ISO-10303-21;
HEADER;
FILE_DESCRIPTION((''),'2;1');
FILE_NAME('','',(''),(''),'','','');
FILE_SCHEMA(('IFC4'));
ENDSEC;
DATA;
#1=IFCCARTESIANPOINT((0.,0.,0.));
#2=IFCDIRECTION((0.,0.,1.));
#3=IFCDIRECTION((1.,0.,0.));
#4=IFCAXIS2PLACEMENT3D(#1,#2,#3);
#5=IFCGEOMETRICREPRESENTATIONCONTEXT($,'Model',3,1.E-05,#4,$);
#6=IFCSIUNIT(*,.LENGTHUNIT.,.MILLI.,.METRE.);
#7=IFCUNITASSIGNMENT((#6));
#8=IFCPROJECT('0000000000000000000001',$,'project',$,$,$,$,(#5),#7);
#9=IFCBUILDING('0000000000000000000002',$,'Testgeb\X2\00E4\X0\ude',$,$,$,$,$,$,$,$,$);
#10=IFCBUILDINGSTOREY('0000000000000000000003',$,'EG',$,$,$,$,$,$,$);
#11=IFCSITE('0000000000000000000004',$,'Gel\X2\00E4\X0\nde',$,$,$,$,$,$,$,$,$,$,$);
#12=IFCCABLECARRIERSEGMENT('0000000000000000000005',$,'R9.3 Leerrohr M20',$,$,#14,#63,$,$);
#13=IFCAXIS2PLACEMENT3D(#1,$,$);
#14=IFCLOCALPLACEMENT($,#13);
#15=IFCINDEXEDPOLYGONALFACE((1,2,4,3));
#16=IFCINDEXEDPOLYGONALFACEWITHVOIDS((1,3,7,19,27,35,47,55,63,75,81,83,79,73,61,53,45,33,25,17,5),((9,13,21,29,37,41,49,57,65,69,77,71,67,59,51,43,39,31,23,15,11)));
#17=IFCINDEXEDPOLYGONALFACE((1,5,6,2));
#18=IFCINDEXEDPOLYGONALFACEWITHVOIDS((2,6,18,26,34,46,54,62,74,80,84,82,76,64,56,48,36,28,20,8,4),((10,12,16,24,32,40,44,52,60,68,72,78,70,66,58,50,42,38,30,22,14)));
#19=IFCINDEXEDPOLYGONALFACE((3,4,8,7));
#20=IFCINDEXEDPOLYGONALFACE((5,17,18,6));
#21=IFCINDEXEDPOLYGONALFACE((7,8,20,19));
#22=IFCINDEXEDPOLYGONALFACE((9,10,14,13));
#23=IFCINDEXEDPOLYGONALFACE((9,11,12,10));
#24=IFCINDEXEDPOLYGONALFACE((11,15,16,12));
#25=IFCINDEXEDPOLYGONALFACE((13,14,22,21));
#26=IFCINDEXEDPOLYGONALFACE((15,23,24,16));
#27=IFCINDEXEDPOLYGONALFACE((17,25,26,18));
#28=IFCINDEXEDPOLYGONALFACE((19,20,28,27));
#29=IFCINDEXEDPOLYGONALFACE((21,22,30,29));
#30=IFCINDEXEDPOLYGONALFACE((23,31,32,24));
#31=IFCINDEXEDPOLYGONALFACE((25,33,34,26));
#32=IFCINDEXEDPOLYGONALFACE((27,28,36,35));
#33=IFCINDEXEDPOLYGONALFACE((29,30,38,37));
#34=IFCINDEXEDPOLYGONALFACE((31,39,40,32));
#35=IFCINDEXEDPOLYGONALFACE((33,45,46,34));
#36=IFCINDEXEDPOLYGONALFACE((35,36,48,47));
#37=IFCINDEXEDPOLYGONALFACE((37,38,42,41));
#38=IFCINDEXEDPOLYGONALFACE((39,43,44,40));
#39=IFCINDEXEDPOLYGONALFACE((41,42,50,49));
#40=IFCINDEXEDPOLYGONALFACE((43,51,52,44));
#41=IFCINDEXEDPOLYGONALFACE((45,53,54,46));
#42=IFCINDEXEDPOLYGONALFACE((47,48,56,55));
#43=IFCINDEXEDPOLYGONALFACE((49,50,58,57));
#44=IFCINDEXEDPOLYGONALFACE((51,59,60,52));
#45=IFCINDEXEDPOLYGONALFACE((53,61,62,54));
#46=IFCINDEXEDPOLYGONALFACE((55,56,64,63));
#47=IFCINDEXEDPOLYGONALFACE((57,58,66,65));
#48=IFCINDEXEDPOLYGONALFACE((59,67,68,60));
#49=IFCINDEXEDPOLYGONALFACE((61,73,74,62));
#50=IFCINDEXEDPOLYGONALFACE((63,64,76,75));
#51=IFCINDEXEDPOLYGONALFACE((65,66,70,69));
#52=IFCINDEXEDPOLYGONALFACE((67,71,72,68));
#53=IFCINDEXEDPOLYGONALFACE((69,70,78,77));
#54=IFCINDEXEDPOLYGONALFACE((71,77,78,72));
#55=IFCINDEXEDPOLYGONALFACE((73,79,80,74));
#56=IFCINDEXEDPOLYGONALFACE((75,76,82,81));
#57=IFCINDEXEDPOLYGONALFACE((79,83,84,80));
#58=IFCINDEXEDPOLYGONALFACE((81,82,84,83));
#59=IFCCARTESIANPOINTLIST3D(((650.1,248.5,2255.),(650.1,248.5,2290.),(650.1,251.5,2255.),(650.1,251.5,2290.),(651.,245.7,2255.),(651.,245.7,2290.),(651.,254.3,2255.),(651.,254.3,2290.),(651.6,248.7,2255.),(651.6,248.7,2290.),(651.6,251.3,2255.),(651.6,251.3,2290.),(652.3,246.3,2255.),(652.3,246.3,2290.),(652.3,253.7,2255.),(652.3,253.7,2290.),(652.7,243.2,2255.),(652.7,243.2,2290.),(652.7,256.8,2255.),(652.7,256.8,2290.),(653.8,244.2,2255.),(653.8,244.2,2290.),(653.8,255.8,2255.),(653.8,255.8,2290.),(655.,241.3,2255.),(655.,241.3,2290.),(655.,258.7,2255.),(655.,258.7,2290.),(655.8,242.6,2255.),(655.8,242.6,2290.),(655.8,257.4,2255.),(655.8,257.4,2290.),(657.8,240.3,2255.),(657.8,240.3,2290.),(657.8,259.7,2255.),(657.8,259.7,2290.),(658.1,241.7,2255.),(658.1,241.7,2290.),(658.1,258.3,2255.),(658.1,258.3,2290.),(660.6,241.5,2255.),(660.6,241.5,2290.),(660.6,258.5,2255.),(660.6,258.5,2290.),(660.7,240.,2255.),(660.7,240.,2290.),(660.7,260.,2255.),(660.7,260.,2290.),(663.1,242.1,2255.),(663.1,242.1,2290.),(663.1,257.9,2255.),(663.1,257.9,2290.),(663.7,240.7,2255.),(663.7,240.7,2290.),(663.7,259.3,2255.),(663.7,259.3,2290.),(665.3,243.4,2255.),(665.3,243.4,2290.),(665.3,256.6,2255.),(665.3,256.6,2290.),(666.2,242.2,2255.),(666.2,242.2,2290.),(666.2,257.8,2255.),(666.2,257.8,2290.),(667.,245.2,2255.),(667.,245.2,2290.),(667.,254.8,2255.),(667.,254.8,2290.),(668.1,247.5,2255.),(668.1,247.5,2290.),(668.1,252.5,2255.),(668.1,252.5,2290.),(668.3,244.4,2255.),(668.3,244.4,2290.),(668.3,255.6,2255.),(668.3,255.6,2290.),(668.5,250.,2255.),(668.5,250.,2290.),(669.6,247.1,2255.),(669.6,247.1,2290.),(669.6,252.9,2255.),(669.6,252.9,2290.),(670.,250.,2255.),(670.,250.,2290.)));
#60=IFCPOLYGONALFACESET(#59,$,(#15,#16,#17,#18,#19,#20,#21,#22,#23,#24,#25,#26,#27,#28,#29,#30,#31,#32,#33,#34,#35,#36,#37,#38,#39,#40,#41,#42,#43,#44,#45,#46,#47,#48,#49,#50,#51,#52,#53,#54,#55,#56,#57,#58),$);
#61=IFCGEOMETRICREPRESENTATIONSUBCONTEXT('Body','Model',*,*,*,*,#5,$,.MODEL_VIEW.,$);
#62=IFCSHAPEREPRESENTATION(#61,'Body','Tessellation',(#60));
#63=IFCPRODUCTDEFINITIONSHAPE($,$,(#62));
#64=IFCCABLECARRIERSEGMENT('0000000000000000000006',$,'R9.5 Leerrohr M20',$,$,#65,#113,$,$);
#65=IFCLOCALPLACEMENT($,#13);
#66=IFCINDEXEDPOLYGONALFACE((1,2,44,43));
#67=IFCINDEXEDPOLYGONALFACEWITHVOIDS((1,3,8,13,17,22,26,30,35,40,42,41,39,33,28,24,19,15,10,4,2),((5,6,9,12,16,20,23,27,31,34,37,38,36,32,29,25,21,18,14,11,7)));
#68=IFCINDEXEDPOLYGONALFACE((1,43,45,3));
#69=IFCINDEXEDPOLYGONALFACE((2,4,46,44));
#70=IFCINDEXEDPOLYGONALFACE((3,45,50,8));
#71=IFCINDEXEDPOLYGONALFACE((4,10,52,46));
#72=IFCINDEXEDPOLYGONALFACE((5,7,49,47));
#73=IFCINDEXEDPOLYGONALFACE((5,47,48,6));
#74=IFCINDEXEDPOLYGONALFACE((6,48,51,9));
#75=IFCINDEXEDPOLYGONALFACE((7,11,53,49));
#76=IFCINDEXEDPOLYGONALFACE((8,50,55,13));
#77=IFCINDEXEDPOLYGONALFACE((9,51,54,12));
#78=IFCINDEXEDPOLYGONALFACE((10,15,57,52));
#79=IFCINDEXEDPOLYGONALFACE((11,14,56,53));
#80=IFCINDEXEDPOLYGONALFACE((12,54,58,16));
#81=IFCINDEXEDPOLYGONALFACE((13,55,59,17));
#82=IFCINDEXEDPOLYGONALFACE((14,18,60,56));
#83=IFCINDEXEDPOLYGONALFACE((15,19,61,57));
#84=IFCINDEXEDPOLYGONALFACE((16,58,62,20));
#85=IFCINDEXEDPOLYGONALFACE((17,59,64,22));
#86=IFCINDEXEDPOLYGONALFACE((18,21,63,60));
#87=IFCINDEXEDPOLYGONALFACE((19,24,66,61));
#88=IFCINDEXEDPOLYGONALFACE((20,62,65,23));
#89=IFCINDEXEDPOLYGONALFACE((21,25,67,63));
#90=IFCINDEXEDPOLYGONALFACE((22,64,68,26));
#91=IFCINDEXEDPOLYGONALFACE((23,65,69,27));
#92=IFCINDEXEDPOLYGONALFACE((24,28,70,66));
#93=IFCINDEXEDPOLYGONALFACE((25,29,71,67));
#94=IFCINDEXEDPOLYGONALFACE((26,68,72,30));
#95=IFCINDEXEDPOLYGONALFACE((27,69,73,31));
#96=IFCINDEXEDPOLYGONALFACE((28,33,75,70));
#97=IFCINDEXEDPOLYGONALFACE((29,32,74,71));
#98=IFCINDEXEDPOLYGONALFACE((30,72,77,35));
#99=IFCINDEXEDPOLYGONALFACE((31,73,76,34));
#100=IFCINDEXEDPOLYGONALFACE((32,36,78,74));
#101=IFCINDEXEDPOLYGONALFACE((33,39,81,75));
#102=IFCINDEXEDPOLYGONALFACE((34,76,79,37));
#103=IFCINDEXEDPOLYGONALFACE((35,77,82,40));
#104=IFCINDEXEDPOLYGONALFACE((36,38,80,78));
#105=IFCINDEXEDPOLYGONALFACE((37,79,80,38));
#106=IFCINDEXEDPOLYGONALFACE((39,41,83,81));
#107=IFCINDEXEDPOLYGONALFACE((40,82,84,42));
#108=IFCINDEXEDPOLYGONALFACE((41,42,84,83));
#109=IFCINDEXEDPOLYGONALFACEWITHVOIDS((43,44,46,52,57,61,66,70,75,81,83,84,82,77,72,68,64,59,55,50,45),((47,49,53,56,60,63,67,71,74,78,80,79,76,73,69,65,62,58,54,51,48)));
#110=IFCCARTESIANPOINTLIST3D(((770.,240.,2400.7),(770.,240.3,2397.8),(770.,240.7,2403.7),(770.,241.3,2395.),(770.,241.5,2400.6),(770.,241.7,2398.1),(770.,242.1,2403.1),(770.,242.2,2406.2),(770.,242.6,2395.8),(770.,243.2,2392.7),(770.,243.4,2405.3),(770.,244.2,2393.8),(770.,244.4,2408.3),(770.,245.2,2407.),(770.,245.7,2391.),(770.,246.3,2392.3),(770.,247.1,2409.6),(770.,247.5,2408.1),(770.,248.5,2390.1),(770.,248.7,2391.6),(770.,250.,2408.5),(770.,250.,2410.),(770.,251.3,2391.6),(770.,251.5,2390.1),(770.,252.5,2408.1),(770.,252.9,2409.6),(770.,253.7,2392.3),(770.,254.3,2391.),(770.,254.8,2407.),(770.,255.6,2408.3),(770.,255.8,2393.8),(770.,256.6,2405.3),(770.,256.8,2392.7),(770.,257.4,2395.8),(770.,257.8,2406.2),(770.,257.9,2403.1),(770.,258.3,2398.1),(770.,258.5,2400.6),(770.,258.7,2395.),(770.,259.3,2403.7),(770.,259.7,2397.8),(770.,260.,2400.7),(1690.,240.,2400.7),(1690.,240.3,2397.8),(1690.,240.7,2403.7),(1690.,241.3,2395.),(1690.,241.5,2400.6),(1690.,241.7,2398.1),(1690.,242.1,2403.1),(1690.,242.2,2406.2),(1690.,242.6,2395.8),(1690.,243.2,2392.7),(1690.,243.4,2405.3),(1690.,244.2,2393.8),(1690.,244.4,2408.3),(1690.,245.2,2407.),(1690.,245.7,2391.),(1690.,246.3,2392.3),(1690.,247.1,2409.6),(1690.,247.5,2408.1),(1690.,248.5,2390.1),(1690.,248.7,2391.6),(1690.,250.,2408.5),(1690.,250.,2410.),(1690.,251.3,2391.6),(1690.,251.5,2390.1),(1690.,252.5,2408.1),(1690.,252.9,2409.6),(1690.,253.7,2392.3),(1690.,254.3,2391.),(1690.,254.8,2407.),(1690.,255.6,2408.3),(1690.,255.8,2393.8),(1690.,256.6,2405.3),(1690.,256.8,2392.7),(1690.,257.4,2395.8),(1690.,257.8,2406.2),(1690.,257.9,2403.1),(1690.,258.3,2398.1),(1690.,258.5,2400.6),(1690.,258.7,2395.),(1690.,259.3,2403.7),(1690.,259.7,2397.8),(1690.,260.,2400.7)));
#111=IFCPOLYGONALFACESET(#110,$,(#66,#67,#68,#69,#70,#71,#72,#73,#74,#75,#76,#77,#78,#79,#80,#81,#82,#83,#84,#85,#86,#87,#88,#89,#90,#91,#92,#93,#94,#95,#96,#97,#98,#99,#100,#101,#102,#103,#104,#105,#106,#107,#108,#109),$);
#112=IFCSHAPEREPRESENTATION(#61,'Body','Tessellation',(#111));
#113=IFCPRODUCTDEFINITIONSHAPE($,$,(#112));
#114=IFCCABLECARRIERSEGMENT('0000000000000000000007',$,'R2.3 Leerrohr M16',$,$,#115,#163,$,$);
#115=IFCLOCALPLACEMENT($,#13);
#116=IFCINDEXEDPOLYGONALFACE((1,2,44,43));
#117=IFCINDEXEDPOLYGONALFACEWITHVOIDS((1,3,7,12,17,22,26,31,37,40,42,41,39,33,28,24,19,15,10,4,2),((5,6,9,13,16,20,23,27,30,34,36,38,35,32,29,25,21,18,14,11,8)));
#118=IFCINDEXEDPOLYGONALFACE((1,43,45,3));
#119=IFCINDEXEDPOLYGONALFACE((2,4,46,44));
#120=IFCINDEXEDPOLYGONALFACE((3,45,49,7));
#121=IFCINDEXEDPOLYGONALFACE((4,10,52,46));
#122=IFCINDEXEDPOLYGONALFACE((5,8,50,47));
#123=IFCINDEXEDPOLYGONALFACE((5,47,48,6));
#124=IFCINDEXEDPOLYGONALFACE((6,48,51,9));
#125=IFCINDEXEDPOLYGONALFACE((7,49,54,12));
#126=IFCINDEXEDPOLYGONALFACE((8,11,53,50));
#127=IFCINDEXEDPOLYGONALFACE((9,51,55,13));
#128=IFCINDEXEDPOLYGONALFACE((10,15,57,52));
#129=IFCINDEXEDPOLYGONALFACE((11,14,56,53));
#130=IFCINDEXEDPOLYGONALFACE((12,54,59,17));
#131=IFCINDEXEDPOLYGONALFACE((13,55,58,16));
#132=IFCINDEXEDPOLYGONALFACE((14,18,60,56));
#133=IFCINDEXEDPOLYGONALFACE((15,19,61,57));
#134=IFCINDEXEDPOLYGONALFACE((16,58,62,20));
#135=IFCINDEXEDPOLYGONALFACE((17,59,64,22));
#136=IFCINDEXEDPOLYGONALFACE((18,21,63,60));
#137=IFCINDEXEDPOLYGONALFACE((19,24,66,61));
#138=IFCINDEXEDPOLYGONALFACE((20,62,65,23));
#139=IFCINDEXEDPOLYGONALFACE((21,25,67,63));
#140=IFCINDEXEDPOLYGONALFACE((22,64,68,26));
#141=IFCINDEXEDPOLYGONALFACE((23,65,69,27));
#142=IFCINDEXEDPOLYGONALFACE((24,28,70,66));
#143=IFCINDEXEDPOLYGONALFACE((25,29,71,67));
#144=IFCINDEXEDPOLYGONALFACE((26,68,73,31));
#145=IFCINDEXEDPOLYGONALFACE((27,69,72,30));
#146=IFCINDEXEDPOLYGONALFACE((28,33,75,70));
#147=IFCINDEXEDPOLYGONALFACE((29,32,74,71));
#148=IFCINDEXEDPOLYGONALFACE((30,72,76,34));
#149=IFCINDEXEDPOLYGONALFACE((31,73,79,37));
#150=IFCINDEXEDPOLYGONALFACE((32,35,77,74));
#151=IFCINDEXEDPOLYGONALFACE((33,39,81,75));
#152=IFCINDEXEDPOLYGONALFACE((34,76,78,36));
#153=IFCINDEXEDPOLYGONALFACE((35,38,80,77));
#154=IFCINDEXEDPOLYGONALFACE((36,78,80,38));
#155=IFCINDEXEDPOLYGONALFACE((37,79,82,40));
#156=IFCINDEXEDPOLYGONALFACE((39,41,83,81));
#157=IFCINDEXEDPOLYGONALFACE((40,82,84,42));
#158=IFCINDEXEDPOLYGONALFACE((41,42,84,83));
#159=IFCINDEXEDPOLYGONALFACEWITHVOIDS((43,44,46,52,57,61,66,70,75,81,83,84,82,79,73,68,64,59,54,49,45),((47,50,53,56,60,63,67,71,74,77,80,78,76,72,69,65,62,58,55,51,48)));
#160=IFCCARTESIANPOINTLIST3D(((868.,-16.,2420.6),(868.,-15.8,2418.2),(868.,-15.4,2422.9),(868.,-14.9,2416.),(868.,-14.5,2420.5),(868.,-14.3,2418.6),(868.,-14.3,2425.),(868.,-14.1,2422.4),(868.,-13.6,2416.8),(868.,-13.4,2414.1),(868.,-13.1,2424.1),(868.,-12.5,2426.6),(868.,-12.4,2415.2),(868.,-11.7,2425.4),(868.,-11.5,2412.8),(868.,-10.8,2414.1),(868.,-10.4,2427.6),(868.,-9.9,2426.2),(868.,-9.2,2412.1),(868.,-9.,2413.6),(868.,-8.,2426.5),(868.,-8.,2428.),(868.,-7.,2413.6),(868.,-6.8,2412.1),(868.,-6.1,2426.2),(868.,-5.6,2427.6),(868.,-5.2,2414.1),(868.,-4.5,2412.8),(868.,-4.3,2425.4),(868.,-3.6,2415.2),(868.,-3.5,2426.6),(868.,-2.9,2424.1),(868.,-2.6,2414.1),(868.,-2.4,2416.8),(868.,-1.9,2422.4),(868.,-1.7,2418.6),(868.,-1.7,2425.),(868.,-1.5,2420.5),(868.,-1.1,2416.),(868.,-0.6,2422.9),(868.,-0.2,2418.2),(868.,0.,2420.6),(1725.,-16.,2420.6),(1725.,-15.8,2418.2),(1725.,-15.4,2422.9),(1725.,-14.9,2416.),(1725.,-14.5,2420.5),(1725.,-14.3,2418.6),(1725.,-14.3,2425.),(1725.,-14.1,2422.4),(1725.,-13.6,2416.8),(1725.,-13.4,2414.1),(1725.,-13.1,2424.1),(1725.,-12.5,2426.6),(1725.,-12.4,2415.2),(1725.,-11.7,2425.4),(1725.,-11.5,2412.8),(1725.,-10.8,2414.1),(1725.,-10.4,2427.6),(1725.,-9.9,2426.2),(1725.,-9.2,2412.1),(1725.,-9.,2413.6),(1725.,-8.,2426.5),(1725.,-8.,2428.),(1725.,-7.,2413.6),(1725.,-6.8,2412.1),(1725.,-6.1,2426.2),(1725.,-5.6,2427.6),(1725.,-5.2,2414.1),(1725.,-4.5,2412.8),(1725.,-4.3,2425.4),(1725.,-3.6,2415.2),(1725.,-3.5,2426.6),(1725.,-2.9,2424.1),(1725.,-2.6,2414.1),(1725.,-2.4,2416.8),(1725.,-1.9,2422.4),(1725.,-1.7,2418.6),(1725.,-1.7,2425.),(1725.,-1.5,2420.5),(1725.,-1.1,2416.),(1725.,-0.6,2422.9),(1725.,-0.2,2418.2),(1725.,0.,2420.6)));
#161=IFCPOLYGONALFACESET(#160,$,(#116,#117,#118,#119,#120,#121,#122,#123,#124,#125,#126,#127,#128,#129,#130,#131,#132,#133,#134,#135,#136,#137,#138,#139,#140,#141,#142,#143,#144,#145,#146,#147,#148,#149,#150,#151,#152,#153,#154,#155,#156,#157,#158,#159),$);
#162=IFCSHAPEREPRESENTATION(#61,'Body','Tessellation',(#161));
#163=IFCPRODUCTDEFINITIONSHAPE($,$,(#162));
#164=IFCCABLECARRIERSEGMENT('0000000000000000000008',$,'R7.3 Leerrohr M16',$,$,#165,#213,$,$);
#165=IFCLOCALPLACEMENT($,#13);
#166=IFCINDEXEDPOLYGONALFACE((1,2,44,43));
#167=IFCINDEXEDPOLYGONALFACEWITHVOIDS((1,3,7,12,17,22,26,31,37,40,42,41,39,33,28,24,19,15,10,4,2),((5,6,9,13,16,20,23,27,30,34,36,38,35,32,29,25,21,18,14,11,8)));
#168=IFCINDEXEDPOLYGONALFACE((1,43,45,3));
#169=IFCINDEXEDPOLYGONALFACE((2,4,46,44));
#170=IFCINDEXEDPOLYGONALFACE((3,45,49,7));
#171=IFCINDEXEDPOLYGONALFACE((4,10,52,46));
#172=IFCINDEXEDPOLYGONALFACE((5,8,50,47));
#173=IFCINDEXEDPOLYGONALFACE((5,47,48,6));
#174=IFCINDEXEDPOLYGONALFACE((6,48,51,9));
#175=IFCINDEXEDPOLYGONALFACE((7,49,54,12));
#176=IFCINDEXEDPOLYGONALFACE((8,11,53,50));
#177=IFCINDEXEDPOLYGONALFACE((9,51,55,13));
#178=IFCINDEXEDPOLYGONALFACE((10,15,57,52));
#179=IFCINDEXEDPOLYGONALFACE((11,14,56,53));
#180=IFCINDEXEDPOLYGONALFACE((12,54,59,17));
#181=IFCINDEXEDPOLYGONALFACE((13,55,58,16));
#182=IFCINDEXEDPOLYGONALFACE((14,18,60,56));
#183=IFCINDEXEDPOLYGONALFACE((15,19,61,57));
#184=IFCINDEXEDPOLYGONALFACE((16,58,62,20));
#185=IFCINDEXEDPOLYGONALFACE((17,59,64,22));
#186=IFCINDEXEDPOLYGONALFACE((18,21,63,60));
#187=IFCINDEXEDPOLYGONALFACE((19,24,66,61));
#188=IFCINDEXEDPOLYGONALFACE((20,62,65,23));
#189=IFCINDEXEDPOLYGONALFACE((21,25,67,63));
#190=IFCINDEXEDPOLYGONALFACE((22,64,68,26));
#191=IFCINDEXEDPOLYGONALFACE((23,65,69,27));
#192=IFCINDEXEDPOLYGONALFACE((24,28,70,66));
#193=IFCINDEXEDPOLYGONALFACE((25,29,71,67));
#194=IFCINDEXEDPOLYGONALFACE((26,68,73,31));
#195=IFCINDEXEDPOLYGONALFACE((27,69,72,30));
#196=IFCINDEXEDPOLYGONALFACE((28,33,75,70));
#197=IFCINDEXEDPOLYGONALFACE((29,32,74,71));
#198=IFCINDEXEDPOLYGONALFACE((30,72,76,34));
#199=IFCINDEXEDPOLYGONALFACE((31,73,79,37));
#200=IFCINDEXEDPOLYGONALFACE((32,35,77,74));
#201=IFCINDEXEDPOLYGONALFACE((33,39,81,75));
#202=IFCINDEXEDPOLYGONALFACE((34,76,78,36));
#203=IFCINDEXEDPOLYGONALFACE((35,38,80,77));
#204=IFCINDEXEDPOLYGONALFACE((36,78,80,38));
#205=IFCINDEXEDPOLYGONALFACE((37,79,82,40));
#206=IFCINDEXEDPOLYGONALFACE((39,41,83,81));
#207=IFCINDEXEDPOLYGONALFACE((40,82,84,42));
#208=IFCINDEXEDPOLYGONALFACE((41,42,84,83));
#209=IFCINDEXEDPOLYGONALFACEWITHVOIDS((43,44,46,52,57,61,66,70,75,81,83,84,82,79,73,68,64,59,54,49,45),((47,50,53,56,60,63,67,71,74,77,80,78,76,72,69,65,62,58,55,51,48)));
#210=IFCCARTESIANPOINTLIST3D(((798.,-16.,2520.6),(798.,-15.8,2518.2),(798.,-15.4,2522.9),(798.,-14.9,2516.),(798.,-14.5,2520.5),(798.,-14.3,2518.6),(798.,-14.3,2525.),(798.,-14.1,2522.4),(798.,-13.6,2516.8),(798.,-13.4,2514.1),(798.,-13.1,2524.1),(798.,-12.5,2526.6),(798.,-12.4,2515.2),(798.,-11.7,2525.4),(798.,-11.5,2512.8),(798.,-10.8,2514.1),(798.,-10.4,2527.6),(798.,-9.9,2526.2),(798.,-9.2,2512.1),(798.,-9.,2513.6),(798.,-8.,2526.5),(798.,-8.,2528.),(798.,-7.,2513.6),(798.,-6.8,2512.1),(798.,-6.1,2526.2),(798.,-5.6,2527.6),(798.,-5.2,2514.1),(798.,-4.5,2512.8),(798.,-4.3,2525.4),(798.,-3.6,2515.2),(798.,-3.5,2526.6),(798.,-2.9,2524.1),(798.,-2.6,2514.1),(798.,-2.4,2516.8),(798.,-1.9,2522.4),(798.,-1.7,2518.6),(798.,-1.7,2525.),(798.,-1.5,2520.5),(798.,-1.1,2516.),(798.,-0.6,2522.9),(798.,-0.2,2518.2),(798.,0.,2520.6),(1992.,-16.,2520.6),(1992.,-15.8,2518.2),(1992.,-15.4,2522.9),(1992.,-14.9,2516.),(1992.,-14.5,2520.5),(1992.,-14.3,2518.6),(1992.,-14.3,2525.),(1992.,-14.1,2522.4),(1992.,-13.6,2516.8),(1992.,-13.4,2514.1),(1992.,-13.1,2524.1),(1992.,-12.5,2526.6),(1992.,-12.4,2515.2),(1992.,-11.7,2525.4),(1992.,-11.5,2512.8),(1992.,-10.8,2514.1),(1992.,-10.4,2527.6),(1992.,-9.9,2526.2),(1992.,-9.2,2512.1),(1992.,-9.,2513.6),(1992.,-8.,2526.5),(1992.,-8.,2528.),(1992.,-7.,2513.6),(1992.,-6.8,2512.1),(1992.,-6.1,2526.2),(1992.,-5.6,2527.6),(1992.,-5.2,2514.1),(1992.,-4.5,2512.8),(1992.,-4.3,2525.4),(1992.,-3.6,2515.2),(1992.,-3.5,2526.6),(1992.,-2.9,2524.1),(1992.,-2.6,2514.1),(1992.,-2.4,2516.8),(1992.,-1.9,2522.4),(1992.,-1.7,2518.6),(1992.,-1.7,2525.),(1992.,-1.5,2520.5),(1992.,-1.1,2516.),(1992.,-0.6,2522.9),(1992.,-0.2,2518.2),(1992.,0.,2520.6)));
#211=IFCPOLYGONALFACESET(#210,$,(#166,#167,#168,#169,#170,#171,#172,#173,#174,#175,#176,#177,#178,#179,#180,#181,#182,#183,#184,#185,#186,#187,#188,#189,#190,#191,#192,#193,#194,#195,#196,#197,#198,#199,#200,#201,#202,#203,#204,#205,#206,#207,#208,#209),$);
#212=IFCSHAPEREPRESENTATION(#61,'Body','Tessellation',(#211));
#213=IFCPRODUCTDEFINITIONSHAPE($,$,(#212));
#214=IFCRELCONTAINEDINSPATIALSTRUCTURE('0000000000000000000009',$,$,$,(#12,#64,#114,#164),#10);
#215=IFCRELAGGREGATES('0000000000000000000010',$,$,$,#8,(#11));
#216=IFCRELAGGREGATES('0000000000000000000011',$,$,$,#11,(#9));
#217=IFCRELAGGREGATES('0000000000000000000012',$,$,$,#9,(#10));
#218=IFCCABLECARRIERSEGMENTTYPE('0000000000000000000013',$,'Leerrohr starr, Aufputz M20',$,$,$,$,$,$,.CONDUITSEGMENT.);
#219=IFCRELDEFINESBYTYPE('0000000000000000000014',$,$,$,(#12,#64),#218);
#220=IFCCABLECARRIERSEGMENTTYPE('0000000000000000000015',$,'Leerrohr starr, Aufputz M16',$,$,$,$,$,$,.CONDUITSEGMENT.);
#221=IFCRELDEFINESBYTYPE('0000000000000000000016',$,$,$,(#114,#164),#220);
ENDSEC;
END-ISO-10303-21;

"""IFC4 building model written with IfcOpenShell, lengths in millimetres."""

from ifc_helpers import new_model, si_unit, frame, origin_with_axes, place, context, subcontext, project, spatial, hollow_circle, extrude, type_object, element, save


model = new_model("IFC4")

# Units and contexts
model_context = context("Model", 3, precision=1e-05, world=origin_with_axes())
body_context = subcontext(model_context, "Body", "Model", "MODEL_VIEW")
ifc_project = project(units=[si_unit("LENGTHUNIT", "METRE", prefix="MILLI")], contexts=[model_context])

# Site, building, storey
site = spatial("IfcSite", under=ifc_project, Name="Gelände")
building = spatial("IfcBuilding", under=site, Name="Testgebäude")
storey = spatial("IfcBuildingStorey", under=building, Name="EG")

# Cable carrier segments
cable_carrier_segment_type_1 = type_object("IfcCableCarrierSegmentType", Name="Leerrohr starr, Aufputz M20", PredefinedType="CONDUITSEGMENT")
cable_carrier_segment_1_placement = place(None, frame((660.0, 250.0, 2255.0), z_axis=(0.0, 0.0, 1.0), x_axis=(1.0, 0.0, 0.0)))
element("IfcCableCarrierSegment", 1, at=cable_carrier_segment_1_placement, inside=storey, type_object=cable_carrier_segment_type_1, Name="R9.3 Leerrohr M20", context=body_context, shape_type="SweptSolid", body=[
    extrude(hollow_circle(Radius=10.0, WallThickness=1.5), None, (0.0, 0.0, 1.0), 35.0),
])
cable_carrier_segment_2_placement = place(None, frame((770.0, 250.0, 2400.0), z_axis=(1.0, 0.0, 0.0), x_axis=(0.0, 0.0, 1.0)))
element("IfcCableCarrierSegment", 2, at=cable_carrier_segment_2_placement, inside=storey, type_object=cable_carrier_segment_type_1, Name="R9.5 Leerrohr M20", context=body_context, shape_type="SweptSolid", body=[
    extrude(hollow_circle(Radius=10.0, WallThickness=1.5), None, (0.0, 0.0, 1.0), 920.0),
])

# Cable carrier segments
cable_carrier_segment_type_2 = type_object("IfcCableCarrierSegmentType", Name="Leerrohr starr, Aufputz M16", PredefinedType="CONDUITSEGMENT")
cable_carrier_segment_3_placement = place(None, frame((868.0, -8.0, 2420.0), z_axis=(1.0, 0.0, 0.0), x_axis=(0.0, 0.0, 1.0)))
element("IfcCableCarrierSegment", 3, at=cable_carrier_segment_3_placement, inside=storey, type_object=cable_carrier_segment_type_2, Name="R2.3 Leerrohr M16", context=body_context, shape_type="SweptSolid", body=[
    extrude(hollow_circle(Radius=8.0, WallThickness=1.5), None, (0.0, 0.0, 1.0), 857.0),
])
cable_carrier_segment_4_placement = place(None, frame((798.0, -8.0, 2520.0), z_axis=(1.0, 0.0, 0.0), x_axis=(0.0, 0.0, 1.0)))
element("IfcCableCarrierSegment", 4, at=cable_carrier_segment_4_placement, inside=storey, type_object=cable_carrier_segment_type_2, Name="R7.3 Leerrohr M16", context=body_context, shape_type="SweptSolid", body=[
    extrude(hollow_circle(Radius=8.0, WallThickness=1.5), None, (0.0, 0.0, 1.0), 1194.0),
])

save(model, "model.ifc")
